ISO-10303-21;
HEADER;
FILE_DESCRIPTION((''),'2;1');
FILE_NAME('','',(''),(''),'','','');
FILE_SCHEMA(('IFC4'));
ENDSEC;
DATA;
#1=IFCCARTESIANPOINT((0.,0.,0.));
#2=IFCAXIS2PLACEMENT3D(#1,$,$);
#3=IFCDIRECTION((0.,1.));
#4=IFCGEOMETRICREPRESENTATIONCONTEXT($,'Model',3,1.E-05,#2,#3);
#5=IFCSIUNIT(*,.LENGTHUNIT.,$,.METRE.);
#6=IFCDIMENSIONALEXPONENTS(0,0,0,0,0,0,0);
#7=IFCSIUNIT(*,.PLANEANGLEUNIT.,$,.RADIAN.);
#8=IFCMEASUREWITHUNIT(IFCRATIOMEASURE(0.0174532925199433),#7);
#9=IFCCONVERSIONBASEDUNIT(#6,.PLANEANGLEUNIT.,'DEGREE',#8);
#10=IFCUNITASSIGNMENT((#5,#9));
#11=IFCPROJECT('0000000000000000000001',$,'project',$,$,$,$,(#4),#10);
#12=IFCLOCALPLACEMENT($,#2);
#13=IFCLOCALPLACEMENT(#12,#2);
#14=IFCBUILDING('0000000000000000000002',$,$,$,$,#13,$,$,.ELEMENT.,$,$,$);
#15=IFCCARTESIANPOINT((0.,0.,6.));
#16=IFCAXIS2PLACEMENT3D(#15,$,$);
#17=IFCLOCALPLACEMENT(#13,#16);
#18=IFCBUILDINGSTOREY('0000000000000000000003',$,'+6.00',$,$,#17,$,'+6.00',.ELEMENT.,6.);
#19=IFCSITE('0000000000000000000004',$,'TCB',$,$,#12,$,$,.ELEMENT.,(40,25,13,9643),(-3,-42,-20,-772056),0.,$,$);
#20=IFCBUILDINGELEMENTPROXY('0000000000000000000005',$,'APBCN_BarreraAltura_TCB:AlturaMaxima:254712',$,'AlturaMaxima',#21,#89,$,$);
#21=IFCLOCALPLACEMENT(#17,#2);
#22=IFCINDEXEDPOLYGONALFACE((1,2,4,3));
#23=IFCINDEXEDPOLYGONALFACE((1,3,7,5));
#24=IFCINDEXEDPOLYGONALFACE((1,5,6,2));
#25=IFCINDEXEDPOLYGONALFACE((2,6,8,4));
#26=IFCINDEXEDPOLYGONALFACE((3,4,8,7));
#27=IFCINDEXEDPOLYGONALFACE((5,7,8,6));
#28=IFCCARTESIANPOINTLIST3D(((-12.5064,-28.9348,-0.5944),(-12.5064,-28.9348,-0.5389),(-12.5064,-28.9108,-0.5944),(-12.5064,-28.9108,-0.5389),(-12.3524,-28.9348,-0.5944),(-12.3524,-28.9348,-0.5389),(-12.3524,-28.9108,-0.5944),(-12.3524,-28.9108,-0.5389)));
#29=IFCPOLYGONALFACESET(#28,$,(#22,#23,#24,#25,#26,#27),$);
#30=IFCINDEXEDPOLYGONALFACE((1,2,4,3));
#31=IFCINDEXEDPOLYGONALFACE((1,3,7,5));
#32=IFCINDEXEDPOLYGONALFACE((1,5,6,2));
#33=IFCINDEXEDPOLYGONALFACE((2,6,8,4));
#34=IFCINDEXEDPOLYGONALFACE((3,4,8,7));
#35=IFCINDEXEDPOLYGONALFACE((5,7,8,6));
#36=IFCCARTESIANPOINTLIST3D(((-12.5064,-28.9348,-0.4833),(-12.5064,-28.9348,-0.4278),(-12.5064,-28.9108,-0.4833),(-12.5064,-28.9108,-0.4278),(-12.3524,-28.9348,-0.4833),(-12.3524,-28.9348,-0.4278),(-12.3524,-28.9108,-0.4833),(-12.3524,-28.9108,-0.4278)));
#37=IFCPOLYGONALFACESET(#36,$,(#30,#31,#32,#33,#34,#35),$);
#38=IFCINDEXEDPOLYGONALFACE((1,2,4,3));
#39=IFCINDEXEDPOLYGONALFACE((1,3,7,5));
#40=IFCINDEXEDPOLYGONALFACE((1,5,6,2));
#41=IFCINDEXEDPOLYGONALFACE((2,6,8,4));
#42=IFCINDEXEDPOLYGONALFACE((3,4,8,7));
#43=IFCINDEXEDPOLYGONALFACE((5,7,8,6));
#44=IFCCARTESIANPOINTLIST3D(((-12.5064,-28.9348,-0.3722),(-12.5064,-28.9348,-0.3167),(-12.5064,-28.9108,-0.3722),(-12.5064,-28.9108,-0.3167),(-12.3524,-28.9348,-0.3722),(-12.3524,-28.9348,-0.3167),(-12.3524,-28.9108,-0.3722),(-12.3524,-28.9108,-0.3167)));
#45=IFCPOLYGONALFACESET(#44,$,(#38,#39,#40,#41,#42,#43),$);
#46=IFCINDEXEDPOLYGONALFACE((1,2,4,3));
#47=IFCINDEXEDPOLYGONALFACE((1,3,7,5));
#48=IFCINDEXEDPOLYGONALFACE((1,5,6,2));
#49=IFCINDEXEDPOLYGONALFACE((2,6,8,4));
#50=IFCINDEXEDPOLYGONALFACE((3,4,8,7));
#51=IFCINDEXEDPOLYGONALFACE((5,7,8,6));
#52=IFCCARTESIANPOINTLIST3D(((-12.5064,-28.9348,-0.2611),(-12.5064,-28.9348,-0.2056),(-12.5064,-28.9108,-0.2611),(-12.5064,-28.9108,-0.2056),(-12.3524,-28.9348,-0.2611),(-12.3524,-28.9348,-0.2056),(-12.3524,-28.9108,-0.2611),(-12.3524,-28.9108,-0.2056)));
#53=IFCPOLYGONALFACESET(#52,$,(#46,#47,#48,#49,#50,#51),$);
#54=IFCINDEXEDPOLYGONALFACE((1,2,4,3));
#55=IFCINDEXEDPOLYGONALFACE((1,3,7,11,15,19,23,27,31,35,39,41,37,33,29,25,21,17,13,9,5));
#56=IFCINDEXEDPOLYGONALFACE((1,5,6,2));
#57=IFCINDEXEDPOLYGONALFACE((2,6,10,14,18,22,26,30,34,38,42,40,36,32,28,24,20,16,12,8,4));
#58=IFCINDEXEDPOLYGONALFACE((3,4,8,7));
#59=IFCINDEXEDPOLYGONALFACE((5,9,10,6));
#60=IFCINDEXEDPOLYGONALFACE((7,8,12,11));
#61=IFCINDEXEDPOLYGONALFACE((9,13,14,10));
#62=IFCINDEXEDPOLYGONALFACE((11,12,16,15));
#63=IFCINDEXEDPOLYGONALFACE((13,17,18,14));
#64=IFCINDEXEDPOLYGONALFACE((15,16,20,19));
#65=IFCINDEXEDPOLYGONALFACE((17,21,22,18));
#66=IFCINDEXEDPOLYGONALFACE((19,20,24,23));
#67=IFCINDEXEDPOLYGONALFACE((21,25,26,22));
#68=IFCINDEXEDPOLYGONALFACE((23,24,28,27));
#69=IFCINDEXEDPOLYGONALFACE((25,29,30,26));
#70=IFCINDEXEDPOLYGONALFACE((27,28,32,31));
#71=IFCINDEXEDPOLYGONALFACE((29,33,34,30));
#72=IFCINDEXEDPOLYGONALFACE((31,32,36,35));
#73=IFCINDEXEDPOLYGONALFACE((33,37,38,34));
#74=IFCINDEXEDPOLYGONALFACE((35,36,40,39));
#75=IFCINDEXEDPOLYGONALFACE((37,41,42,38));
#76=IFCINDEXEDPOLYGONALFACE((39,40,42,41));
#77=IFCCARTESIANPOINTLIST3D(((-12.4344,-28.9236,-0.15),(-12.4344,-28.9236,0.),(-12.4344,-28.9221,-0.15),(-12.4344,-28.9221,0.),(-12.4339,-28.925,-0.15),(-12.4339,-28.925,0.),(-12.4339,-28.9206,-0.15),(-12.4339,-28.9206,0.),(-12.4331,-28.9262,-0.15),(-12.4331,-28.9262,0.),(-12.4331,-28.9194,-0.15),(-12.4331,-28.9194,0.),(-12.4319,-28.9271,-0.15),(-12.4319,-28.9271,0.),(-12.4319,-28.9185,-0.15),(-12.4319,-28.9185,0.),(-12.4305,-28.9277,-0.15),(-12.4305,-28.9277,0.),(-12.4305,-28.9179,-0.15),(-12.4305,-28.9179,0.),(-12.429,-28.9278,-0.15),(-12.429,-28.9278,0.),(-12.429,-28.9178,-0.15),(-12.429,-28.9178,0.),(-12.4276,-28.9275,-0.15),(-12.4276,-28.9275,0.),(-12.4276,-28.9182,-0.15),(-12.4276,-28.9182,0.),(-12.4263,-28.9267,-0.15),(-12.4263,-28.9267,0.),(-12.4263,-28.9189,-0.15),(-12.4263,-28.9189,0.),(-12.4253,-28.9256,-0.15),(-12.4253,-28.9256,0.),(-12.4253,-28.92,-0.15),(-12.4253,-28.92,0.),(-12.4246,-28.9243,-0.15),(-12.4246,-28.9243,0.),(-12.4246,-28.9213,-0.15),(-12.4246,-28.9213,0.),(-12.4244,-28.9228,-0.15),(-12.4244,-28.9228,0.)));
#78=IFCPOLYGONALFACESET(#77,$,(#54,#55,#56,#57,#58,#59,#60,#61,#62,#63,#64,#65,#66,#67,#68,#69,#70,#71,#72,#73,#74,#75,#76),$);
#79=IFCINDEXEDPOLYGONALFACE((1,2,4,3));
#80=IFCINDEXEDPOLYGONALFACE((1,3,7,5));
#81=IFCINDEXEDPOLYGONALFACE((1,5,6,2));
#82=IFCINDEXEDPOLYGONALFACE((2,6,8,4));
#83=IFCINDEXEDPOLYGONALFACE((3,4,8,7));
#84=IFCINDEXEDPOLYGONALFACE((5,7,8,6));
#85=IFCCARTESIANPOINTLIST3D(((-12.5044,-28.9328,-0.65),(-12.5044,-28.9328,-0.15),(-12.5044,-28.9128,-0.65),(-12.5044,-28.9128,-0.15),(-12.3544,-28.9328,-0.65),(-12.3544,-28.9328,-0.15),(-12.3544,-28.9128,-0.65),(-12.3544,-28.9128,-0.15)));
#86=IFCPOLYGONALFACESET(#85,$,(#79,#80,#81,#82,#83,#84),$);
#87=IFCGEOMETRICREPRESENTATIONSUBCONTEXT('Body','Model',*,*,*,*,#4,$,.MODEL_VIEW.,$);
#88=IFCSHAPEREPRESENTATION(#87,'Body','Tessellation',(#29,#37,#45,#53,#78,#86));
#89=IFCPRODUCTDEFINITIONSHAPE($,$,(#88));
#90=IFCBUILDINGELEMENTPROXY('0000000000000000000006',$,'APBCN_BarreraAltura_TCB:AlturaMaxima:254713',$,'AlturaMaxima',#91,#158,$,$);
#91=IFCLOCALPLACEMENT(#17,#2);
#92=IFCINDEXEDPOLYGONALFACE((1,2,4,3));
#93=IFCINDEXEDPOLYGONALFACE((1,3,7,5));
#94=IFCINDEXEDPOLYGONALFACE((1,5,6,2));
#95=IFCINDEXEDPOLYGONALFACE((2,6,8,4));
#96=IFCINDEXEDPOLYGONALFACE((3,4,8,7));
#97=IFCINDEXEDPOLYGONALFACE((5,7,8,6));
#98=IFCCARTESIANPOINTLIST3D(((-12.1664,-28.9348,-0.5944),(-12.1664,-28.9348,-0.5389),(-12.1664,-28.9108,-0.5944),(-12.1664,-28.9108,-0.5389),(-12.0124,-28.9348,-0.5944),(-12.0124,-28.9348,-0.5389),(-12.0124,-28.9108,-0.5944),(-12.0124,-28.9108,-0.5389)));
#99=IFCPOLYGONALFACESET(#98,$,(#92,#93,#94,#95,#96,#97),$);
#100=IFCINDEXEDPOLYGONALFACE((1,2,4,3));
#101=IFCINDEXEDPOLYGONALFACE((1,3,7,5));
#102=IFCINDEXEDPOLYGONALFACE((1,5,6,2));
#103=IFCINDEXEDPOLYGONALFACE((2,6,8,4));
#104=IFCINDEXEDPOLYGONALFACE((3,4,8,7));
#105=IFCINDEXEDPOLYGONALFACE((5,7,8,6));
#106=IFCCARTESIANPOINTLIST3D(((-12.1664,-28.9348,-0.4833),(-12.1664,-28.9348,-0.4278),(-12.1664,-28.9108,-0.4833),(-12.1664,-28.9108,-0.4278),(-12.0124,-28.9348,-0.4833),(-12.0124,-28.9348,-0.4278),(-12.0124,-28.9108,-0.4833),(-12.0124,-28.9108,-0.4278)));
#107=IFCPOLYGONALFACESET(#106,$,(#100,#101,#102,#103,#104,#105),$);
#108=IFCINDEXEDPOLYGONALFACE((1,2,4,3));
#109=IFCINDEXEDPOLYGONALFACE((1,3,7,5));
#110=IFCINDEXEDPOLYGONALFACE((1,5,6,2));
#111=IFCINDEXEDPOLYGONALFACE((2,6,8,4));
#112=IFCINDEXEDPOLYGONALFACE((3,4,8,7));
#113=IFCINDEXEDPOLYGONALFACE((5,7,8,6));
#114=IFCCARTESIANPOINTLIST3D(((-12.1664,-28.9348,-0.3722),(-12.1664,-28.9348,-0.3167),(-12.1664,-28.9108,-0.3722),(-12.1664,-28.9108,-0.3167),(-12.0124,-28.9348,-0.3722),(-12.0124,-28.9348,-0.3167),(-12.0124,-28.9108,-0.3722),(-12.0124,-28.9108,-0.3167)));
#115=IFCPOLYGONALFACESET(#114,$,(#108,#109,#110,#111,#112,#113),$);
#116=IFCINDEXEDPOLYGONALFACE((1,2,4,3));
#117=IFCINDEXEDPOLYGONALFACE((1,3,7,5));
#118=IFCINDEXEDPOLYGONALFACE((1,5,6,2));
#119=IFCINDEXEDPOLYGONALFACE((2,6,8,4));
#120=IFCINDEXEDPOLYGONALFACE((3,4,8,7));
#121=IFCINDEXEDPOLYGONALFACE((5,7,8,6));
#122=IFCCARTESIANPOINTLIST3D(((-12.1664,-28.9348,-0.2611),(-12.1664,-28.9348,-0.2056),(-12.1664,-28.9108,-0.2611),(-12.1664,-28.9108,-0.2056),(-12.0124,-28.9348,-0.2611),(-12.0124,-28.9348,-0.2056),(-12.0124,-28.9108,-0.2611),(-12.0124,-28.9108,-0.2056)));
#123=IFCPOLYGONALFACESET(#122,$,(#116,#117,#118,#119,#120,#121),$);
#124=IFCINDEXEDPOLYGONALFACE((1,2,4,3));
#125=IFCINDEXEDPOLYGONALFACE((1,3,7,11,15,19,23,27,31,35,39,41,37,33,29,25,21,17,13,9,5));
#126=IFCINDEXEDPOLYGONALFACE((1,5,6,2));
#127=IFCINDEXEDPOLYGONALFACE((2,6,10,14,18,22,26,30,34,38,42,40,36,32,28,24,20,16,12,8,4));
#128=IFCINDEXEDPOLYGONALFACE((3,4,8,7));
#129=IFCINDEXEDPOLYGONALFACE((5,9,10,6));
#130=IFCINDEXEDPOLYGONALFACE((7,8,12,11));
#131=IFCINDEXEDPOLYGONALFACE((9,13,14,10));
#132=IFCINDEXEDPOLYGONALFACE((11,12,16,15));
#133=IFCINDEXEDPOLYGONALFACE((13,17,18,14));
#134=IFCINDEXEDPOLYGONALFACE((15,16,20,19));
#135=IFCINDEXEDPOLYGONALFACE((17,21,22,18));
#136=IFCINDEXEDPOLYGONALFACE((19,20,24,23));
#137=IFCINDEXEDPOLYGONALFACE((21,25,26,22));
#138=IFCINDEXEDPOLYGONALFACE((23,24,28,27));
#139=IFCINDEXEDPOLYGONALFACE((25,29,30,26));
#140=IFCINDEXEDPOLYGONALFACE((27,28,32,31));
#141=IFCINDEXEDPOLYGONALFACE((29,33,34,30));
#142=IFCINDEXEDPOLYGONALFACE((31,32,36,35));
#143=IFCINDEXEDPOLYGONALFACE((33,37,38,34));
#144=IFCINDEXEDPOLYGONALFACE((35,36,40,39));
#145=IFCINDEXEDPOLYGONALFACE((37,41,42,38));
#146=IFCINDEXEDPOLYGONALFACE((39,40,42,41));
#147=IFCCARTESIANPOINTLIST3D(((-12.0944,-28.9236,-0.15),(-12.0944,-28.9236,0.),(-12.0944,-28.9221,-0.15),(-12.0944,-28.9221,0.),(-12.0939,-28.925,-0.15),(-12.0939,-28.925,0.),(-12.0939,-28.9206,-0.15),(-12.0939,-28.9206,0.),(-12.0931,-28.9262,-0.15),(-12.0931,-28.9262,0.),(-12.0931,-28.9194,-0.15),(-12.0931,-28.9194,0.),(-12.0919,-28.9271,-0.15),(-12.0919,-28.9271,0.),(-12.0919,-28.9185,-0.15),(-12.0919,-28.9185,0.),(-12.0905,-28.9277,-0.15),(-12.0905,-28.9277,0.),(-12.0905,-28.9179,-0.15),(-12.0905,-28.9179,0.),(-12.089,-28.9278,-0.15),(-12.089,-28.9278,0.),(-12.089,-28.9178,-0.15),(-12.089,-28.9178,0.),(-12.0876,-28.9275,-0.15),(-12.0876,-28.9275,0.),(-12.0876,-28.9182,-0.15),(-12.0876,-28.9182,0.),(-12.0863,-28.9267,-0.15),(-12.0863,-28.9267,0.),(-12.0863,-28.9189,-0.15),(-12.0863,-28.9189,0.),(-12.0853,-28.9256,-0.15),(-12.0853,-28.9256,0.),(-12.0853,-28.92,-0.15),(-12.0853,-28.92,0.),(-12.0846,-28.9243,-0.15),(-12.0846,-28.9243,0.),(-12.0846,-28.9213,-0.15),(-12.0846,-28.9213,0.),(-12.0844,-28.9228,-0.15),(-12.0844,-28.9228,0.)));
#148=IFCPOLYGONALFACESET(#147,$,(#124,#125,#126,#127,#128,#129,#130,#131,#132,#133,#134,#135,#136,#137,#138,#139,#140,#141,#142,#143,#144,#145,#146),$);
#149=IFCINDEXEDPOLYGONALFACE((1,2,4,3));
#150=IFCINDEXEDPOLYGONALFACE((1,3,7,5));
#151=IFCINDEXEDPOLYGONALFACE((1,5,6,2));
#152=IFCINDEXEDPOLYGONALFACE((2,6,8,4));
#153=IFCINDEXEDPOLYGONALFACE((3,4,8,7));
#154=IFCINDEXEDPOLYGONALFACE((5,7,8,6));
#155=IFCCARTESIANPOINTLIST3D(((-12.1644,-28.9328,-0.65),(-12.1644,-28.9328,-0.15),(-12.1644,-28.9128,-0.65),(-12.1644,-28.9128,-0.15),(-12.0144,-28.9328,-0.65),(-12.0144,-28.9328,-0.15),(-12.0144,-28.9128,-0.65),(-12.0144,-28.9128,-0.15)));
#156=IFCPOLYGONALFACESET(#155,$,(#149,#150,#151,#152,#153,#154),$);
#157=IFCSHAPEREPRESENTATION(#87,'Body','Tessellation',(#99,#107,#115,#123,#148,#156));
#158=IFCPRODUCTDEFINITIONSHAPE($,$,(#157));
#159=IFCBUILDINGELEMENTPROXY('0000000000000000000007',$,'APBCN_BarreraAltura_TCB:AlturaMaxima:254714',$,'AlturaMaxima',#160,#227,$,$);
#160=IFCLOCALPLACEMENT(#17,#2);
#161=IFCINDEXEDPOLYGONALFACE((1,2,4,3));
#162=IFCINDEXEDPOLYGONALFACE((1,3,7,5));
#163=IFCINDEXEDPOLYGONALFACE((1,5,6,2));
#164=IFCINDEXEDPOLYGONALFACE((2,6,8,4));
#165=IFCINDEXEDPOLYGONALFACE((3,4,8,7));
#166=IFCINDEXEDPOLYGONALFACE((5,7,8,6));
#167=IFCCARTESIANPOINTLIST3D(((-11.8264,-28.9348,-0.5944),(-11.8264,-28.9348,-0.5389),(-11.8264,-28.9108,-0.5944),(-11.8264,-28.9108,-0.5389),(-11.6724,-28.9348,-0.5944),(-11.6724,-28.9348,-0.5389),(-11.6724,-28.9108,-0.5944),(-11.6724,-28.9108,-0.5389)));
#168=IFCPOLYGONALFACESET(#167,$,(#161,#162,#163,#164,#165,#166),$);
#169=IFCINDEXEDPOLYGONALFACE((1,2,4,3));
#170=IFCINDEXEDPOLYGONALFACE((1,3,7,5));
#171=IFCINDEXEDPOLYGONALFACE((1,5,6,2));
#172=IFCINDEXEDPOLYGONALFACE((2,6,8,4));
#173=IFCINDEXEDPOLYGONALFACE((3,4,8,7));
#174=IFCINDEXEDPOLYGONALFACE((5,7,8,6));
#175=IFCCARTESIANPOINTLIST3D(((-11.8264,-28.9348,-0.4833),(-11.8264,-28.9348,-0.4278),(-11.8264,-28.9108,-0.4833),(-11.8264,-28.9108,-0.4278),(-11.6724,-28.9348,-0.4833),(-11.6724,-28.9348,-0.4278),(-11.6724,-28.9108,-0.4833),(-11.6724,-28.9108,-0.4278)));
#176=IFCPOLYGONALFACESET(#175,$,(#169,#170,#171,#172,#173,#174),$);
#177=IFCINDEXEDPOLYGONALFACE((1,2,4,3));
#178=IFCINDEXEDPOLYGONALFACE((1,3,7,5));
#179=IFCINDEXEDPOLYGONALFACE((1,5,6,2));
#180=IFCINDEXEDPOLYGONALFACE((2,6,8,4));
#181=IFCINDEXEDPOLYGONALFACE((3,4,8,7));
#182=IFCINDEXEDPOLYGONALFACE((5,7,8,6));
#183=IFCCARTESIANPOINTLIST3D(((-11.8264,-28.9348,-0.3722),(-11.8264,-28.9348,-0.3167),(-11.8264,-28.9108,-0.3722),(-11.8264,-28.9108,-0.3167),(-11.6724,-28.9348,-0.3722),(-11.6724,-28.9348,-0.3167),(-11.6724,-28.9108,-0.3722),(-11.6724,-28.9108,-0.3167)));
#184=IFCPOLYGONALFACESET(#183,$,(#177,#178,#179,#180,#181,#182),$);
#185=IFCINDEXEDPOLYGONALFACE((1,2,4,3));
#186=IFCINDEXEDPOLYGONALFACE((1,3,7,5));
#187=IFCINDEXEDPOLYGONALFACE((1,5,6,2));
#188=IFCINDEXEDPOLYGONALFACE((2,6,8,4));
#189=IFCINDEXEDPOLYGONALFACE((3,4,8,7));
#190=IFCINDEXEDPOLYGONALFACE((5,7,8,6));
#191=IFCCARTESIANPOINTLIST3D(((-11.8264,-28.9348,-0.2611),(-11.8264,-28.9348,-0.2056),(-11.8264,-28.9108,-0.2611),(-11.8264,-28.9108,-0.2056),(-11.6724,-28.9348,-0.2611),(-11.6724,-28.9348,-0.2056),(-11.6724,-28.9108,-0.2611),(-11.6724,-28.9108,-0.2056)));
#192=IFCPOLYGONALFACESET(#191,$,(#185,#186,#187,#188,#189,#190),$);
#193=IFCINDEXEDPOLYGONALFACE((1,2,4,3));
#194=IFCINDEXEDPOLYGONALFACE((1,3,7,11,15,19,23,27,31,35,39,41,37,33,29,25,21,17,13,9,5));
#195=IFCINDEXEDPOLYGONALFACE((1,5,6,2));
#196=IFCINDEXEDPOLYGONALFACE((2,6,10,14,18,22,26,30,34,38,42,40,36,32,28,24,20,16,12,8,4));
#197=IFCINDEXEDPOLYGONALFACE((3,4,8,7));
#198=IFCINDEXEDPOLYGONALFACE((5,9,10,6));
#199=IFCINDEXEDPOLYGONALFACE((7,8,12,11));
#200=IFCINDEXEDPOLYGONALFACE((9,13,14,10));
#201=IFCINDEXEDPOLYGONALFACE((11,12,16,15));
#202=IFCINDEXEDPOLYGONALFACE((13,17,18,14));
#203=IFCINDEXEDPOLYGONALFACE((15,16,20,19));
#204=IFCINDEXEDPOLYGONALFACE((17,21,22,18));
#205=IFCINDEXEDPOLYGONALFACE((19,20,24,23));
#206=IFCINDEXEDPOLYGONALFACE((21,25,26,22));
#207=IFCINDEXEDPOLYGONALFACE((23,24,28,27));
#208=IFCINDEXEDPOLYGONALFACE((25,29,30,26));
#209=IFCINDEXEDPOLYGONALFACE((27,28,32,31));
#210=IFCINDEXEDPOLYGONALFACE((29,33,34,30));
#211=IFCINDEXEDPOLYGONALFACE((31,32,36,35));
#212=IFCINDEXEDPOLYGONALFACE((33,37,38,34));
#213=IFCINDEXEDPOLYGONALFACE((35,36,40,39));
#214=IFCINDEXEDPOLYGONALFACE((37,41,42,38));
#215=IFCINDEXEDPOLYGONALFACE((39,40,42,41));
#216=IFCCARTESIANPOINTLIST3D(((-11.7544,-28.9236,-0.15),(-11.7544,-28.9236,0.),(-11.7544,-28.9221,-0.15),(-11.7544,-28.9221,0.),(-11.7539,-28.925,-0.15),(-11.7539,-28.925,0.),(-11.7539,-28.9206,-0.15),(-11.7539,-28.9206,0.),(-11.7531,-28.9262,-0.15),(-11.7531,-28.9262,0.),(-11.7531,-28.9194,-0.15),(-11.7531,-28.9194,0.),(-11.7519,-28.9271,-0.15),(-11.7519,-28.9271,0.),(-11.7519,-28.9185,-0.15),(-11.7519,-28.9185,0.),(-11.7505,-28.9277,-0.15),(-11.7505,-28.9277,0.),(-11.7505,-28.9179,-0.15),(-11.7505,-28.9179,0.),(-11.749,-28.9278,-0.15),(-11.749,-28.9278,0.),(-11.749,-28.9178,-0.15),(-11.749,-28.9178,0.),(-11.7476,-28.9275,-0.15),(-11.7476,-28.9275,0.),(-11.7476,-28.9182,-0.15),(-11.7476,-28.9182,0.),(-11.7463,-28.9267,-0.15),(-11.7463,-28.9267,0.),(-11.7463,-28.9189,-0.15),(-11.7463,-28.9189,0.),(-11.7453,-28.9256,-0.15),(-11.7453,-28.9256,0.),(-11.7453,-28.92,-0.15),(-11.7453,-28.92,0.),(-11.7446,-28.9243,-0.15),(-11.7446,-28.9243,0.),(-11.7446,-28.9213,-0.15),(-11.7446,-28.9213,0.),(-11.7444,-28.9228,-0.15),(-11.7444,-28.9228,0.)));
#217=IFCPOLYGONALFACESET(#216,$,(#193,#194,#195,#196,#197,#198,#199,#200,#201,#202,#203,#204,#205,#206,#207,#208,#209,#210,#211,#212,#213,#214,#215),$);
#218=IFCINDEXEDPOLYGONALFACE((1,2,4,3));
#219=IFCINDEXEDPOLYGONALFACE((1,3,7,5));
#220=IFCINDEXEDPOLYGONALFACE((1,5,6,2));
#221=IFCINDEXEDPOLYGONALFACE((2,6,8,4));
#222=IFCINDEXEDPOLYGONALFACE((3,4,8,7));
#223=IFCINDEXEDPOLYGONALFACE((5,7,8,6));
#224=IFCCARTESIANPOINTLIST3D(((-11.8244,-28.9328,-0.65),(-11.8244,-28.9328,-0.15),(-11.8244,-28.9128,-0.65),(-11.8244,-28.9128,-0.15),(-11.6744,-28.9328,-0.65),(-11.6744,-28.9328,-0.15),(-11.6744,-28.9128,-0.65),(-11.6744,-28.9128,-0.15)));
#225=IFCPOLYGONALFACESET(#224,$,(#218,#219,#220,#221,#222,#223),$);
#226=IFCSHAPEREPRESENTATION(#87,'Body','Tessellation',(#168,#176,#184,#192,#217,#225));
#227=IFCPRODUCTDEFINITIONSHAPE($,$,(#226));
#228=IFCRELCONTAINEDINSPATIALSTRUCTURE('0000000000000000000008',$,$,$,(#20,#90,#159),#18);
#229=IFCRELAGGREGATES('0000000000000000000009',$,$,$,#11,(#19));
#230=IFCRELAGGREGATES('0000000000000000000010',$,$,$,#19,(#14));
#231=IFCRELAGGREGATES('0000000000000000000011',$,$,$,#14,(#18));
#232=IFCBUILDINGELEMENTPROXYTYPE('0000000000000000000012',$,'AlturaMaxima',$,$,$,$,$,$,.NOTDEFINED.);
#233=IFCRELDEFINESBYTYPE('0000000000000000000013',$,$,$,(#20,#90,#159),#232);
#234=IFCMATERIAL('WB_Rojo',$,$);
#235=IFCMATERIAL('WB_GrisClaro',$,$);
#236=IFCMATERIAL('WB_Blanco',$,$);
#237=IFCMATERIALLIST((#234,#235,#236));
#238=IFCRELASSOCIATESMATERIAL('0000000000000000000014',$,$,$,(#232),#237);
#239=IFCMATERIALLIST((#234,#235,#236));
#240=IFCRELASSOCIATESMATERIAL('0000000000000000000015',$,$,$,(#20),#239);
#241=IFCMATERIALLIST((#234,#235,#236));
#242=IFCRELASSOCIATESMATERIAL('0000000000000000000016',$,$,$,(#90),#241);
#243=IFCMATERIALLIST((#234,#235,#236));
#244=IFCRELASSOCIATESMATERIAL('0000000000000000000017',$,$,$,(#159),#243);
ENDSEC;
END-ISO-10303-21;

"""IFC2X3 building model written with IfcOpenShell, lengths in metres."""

from ifc_helpers import new_model, entity, si_unit, converted_unit, direction, frame, frame_2d, origin, origin_2d_with_axis, place, context, subcontext, project, spatial, rectangle, circle, extrude, source, transform, mapped, material, material_list, type_object, type_shapes, element, save


model = new_model("IFC2X3")

# Units and contexts
model_context = context("Model", 3, precision=1e-05, world=origin(), true_north=direction((0.0, 1.0)))
body_context = subcontext(model_context, "Body", "Model", "MODEL_VIEW")
ifc_project = project(units=[si_unit("LENGTHUNIT", "METRE"), converted_unit("PLANEANGLEUNIT", "DEGREE", entity("IfcRatioMeasure", 0.0174532925199433), si_unit("PLANEANGLEUNIT", "RADIAN"), dimensions=[0, 0, 0, 0, 0, 0, 0])], contexts=[model_context])

# Site, building, storey
site_placement = place(None, origin())
site = spatial("IfcSite", under=ifc_project, at=site_placement, Name="TCB", CompositionType="ELEMENT", RefLatitude=(40, 25, 13, 9643), RefLongitude=(-3, -42, -20, -772056), RefElevation=0.0)
building_placement = place(site_placement, origin())
building = spatial("IfcBuilding", under=site, at=building_placement, CompositionType="ELEMENT")
storey_placement = place(building_placement, frame((0.0, 0.0, 6.0)))
storey = spatial("IfcBuildingStorey", under=building, at=storey_placement, Name="+6.00", LongName="+6.00", CompositionType="ELEMENT", Elevation=6.0)

# Building element proxies
ifc_material_1 = material(Name="WB_Rojo")
ifc_material_2 = material(Name="WB_GrisClaro")
ifc_material_3 = material(Name="WB_Blanco")
ifc_material_list_1 = material_list([ifc_material_1, ifc_material_2, ifc_material_3])
ifc_material_list_2 = material_list([ifc_material_1, ifc_material_2, ifc_material_3])
building_element_proxy_type = type_object("IfcBuildingElementProxyType", Name="AlturaMaxima", PredefinedType="NOTDEFINED", material=ifc_material_list_2)
shared_shape = source(origin(), body_context, "Body", "SweptSolid", [
    extrude(rectangle(XDim=0.154, YDim=0.024, at=frame_2d((0.0, 0.0), x_axis=(1.0, 0.0))), frame((0.0, 0.0, -0.5944), z_axis=(0.0, 0.0, 1.0), x_axis=(-1.0, 0.0, 0.0)), (0.0, 0.0, 1.0), 0.0556),
    extrude(rectangle(XDim=0.154, YDim=0.024, at=frame_2d((0.0, 0.0), x_axis=(1.0, 0.0))), frame((0.0, 0.0, -0.4833), z_axis=(0.0, 0.0, 1.0), x_axis=(-1.0, 0.0, 0.0)), (0.0, 0.0, 1.0), 0.0556),
    extrude(rectangle(XDim=0.154, YDim=0.024, at=frame_2d((0.0, 0.0), x_axis=(1.0, 0.0))), frame((0.0, 0.0, -0.3722), z_axis=(0.0, 0.0, 1.0), x_axis=(-1.0, 0.0, 0.0)), (0.0, 0.0, 1.0), 0.0556),
    extrude(rectangle(XDim=0.154, YDim=0.024, at=frame_2d((0.0, 0.0), x_axis=(1.0, 0.0))), frame((0.0, 0.0, -0.2611), z_axis=(0.0, 0.0, 1.0), x_axis=(-1.0, 0.0, 0.0)), (0.0, 0.0, 1.0), 0.0556),
    extrude(circle(Radius=0.005, at=frame_2d((0.0, 0.0), x_axis=(1.0, 0.0))), frame((0.0, 0.0, -0.15)), (0.0, 0.0, 1.0), 0.15),
    extrude(rectangle(XDim=0.02, YDim=0.15, at=origin_2d_with_axis()), frame((0.0, 0.0, -0.65), z_axis=(0.0, 0.0, 1.0), x_axis=(0.0, 1.0, 0.0)), (0.0, 0.0, 1.0), 0.5),
])
type_shapes(building_element_proxy_type, [shared_shape])
proxy_1_placement = place(storey_placement, frame((-12.4294, -28.9228, 0.0)))
element("IfcBuildingElementProxy", 1, at=proxy_1_placement, inside=storey, type_object=building_element_proxy_type, material=ifc_material_list_1, Name="APBCN_BarreraAltura_TCB:AlturaMaxima:254712", ObjectType="AlturaMaxima", context=body_context, shape_type="MappedRepresentation", body=[
    mapped(shared_shape, transform((0.0, 0.0, 0.0), scale=1.0)),
])
ifc_material_list_3 = material_list([ifc_material_1, ifc_material_2, ifc_material_3])
proxy_2_placement = place(storey_placement, frame((-12.0894, -28.9228, 0.0)))
element("IfcBuildingElementProxy", 2, at=proxy_2_placement, inside=storey, type_object=building_element_proxy_type, material=ifc_material_list_3, Name="APBCN_BarreraAltura_TCB:AlturaMaxima:254713", ObjectType="AlturaMaxima", context=body_context, shape_type="MappedRepresentation", body=[
    mapped(shared_shape, transform((0.0, 0.0, 0.0), scale=1.0)),
])
ifc_material_list_4 = material_list([ifc_material_1, ifc_material_2, ifc_material_3])
proxy_3_placement = place(storey_placement, frame((-11.7494, -28.9228, 0.0)))
element("IfcBuildingElementProxy", 3, at=proxy_3_placement, inside=storey, type_object=building_element_proxy_type, material=ifc_material_list_4, Name="APBCN_BarreraAltura_TCB:AlturaMaxima:254714", ObjectType="AlturaMaxima", context=body_context, shape_type="MappedRepresentation", body=[
    mapped(shared_shape, transform((0.0, 0.0, 0.0), scale=1.0)),
])

save(model, "model.ifc")
